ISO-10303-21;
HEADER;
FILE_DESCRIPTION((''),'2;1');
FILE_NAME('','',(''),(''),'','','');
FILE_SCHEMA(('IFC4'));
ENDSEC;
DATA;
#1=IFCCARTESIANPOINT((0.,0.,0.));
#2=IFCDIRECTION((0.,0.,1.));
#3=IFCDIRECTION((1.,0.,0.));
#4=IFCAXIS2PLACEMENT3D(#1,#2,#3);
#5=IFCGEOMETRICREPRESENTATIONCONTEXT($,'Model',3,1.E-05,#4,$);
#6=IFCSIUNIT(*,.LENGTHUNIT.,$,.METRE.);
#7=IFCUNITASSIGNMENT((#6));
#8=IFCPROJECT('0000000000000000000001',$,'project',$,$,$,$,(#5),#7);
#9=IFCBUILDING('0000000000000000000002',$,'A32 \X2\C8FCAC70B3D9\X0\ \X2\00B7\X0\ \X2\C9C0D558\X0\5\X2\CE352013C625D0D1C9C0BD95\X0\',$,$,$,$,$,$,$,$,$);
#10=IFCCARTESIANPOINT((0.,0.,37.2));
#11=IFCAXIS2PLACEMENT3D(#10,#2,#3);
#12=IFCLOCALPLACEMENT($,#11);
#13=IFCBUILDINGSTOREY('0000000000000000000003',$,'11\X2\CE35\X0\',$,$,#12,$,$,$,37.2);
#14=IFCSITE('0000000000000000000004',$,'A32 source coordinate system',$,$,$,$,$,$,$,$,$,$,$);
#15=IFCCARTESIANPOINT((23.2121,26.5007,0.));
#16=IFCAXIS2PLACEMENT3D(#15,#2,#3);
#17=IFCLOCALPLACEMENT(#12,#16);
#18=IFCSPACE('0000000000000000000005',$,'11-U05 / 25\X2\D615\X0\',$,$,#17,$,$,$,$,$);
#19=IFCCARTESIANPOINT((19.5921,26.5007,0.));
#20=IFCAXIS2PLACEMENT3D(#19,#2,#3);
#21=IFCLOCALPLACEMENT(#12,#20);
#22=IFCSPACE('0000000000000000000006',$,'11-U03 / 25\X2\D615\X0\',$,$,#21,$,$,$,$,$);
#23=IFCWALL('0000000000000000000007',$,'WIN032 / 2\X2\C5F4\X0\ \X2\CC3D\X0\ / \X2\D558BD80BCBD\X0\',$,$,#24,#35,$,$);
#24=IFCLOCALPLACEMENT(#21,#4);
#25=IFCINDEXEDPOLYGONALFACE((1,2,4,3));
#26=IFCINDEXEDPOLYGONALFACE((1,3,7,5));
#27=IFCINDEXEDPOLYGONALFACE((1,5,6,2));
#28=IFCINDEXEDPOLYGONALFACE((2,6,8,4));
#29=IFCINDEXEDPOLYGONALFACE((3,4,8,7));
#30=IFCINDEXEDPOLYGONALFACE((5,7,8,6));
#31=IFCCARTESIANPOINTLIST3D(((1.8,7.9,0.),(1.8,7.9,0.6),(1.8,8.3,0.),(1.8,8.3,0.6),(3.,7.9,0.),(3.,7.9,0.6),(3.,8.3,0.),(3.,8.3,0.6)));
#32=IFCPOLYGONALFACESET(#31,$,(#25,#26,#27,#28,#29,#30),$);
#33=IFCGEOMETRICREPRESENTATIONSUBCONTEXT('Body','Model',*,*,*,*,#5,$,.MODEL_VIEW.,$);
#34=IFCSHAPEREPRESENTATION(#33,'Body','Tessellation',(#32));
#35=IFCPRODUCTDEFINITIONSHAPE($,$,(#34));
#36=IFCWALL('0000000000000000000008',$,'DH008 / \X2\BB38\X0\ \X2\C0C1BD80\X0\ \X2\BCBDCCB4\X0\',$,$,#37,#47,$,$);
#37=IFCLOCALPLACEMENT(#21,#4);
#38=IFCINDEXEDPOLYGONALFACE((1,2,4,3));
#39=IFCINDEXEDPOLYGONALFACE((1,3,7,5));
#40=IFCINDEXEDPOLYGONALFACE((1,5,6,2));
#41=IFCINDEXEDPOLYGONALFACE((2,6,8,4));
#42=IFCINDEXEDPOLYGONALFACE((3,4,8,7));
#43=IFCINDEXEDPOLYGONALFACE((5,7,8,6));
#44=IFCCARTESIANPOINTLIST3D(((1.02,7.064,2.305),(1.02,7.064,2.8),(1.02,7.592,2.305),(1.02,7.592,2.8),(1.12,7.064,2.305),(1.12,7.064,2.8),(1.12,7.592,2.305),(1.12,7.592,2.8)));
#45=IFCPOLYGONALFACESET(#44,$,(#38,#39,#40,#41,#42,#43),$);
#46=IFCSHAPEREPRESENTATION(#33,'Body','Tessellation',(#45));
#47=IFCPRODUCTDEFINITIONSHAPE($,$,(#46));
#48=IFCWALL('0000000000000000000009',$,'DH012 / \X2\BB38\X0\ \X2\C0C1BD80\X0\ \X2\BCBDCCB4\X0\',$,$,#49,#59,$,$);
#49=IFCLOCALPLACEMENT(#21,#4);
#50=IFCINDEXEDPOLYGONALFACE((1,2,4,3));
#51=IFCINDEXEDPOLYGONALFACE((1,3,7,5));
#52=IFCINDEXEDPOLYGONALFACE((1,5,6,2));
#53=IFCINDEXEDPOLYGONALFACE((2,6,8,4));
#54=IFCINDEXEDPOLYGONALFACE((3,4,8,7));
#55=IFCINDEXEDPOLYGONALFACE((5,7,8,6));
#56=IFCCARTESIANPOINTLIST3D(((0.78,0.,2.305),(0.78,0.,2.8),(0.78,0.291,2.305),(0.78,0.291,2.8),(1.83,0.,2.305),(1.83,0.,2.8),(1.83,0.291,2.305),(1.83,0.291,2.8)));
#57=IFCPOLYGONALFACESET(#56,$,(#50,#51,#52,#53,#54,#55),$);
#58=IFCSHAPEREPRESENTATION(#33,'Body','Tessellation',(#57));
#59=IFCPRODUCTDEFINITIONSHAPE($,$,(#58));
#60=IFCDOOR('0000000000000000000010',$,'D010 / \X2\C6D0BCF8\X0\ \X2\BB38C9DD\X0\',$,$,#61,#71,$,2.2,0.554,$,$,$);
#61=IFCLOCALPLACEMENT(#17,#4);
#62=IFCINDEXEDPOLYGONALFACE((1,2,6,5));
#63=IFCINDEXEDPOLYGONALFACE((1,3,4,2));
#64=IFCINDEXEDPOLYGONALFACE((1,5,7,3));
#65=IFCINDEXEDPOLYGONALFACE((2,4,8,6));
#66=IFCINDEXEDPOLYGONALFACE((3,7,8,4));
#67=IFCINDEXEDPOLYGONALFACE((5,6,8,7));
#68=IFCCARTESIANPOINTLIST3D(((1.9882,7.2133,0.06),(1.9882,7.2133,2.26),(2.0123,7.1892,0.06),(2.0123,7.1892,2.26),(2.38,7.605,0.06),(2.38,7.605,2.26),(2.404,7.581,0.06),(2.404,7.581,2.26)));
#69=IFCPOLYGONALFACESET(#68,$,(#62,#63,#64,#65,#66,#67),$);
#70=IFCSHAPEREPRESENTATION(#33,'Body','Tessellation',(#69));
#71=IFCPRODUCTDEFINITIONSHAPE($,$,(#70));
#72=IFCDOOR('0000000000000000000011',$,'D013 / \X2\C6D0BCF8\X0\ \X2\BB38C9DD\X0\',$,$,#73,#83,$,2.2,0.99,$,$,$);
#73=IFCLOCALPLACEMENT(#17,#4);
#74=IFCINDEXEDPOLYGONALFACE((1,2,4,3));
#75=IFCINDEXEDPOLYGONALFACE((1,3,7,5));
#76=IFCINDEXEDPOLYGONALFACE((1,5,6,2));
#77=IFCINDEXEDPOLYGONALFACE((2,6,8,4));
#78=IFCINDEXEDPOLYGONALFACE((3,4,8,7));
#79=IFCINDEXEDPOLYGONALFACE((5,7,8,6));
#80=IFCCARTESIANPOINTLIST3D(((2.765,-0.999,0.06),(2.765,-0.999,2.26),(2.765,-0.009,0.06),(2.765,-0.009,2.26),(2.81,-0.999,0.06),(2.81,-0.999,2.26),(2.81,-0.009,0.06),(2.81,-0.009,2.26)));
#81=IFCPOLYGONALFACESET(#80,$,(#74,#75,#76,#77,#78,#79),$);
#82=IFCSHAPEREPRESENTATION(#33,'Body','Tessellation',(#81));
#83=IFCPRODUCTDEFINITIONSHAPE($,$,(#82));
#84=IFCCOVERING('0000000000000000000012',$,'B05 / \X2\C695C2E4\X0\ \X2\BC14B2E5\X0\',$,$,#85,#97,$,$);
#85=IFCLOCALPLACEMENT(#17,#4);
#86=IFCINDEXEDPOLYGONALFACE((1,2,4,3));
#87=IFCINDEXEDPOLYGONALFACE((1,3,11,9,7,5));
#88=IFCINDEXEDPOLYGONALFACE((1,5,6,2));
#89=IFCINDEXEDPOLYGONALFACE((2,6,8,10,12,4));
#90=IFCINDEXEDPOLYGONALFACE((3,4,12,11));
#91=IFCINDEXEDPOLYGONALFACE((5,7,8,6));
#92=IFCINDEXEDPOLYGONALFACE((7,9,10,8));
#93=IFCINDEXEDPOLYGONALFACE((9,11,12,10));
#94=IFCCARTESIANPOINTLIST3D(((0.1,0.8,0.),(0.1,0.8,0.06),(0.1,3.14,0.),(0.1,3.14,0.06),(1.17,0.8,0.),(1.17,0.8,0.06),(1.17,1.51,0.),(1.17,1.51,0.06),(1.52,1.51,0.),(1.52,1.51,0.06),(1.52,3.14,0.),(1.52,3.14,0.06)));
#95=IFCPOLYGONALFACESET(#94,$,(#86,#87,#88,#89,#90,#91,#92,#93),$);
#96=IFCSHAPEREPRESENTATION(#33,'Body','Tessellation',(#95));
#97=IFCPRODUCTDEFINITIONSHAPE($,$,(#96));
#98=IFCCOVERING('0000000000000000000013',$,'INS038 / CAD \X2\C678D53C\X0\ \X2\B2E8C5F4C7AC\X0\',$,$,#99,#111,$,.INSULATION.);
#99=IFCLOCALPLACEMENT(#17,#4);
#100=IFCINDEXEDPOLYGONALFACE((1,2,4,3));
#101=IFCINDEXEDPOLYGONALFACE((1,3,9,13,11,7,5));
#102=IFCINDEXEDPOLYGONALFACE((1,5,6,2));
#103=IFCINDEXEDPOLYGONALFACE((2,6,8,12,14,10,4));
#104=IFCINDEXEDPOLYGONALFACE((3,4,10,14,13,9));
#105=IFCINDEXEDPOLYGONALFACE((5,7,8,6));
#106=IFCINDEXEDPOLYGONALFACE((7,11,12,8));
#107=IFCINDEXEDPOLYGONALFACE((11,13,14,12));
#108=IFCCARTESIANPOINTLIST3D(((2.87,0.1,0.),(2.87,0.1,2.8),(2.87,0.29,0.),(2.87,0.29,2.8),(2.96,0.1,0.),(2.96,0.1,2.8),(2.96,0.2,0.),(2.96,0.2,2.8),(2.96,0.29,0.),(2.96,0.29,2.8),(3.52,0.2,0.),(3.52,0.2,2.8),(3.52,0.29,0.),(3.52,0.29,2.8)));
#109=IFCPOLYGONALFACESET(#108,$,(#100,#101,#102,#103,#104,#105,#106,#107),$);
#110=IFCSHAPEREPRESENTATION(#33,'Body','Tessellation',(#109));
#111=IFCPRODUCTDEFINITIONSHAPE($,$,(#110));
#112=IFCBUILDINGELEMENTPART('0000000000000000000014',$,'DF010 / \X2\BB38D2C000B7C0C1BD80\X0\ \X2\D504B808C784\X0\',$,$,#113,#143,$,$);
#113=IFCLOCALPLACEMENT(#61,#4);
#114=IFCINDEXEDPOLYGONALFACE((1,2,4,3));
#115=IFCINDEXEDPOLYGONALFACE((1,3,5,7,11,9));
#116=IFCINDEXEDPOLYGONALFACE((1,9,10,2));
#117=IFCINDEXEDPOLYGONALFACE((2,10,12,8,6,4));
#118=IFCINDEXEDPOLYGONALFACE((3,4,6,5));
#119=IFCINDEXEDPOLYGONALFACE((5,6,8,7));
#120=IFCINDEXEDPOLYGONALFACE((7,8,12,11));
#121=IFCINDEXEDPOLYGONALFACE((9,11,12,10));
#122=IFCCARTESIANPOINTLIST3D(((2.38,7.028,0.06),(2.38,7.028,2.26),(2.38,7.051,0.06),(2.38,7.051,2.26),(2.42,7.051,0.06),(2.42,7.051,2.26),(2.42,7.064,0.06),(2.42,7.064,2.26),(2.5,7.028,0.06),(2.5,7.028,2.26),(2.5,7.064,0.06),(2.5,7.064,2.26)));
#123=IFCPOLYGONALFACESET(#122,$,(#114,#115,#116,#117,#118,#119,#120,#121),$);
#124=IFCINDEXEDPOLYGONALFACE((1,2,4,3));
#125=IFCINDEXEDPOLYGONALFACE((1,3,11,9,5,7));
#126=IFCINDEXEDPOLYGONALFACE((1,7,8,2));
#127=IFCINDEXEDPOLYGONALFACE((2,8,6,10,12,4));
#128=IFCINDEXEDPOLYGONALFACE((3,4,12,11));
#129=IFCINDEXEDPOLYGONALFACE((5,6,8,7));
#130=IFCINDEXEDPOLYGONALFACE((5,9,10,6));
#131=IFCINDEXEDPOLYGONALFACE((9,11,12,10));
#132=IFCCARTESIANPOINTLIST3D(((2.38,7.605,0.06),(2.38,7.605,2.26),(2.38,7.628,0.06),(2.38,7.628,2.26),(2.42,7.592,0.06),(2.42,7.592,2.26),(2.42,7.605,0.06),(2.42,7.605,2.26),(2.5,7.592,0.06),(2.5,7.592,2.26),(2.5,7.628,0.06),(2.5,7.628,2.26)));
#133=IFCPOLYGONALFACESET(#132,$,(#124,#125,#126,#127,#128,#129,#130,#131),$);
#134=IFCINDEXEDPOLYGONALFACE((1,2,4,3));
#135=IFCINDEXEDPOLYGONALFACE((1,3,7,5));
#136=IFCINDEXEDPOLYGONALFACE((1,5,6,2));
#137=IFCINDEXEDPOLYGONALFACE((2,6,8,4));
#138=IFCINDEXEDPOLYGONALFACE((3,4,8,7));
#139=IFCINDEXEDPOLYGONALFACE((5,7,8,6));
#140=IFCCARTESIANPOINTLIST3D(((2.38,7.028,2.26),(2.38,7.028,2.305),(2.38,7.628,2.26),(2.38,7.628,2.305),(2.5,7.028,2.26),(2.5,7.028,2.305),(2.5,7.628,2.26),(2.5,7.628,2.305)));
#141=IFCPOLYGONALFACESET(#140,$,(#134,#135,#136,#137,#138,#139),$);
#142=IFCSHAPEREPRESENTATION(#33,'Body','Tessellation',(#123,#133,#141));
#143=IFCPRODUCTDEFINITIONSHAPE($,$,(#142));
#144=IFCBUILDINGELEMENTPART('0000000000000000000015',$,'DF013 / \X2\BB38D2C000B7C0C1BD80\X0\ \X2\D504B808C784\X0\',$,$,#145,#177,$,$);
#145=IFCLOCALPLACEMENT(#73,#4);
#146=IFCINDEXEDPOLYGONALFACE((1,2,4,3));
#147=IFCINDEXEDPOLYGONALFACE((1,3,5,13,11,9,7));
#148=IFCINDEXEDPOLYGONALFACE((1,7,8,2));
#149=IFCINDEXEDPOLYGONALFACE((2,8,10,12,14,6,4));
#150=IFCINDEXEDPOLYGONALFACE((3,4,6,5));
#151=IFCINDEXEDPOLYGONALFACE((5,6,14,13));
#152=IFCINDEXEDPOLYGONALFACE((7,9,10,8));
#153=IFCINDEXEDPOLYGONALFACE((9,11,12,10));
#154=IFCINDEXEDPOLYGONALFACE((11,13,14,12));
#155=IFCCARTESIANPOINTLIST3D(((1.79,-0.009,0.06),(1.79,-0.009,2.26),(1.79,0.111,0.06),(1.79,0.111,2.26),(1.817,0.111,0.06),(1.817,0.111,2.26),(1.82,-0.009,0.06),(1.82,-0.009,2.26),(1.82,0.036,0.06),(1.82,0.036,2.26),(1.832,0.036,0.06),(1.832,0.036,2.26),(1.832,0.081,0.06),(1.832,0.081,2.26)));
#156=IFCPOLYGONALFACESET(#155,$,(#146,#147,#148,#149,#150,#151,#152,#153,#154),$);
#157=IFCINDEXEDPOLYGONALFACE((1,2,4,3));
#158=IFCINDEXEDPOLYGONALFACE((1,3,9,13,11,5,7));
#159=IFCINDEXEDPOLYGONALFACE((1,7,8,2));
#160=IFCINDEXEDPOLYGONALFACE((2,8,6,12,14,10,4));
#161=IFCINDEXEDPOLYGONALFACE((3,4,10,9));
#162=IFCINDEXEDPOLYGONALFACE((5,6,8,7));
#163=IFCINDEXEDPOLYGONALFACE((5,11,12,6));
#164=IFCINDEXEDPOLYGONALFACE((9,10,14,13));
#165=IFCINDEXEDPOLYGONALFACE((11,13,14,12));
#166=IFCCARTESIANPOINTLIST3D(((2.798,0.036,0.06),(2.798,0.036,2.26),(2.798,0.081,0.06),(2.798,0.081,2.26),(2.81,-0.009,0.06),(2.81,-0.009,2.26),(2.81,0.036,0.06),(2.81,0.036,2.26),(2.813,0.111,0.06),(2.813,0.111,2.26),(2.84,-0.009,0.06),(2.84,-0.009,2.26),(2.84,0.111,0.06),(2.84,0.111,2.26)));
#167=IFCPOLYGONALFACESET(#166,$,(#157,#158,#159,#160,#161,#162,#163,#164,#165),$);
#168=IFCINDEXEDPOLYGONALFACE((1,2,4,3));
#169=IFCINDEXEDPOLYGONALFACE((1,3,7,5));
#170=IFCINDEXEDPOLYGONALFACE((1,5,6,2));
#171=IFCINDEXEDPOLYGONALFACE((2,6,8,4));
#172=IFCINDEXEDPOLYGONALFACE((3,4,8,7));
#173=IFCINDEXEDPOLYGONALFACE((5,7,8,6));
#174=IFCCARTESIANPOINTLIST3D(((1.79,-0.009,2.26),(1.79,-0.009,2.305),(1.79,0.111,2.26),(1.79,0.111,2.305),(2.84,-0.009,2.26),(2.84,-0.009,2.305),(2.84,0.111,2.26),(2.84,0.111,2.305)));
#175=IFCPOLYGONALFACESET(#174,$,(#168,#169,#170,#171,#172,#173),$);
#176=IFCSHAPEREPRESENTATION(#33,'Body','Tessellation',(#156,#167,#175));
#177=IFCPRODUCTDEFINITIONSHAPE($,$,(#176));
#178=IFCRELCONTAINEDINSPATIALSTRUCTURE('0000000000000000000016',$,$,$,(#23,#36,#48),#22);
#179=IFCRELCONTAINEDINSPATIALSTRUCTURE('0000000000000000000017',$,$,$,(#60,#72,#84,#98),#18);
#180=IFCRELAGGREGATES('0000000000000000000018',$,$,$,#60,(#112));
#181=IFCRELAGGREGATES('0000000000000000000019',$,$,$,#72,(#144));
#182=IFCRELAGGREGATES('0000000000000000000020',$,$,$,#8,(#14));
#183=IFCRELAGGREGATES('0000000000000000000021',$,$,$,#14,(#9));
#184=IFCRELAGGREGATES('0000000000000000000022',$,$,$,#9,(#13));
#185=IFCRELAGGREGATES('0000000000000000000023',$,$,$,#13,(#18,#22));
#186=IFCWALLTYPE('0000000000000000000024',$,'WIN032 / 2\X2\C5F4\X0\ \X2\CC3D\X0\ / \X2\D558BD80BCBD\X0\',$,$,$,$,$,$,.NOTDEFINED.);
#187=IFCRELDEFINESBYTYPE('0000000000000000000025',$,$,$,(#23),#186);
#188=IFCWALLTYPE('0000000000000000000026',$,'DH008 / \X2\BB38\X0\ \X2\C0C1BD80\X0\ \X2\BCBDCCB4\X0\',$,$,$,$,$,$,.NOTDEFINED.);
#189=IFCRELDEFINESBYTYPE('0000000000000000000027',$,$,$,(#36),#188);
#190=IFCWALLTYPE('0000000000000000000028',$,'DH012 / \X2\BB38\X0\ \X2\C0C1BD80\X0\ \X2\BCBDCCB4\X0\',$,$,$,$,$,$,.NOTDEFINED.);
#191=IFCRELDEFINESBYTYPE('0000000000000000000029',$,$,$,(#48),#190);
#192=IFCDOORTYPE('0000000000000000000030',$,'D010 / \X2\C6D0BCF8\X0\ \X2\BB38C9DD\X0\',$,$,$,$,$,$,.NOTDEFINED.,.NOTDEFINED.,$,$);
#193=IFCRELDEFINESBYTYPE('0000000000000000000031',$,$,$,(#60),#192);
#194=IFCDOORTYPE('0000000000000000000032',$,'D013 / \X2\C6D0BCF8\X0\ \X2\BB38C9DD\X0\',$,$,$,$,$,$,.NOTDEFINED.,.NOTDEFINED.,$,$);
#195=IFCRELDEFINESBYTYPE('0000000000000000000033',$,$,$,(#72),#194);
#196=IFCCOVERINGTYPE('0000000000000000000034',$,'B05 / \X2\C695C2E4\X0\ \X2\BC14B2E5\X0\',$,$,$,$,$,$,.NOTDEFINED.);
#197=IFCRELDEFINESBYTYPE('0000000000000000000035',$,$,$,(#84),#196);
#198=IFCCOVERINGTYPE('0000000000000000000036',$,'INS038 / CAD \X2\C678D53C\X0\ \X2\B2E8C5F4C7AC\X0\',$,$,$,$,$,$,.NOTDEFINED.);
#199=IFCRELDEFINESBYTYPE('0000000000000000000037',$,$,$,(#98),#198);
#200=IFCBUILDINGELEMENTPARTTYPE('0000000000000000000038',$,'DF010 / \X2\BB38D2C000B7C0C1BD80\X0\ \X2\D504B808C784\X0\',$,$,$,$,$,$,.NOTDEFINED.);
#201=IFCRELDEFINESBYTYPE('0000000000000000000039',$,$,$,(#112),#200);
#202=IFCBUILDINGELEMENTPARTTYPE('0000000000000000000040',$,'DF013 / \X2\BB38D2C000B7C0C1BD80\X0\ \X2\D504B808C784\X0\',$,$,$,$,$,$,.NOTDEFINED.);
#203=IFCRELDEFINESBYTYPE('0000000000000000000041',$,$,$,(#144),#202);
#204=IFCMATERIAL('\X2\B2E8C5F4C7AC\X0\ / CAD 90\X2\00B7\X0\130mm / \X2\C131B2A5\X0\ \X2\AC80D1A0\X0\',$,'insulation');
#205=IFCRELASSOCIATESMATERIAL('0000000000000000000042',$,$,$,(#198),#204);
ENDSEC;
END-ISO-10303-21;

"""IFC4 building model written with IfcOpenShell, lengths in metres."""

from ifc_helpers import new_model, si_unit, frame, origin, origin_with_axes, place, context, subcontext, project, spatial, polyline, outline, extrude, source, transform, mapped, material, type_object, type_shapes, element, aggregate, save


model = new_model("IFC4")

# Units and contexts
model_context = context("Model", 3, precision=1e-05, world=origin_with_axes())
body_context = subcontext(model_context, "Body", "Model", "MODEL_VIEW")
ifc_project = project(units=[si_unit("LENGTHUNIT", "METRE")], contexts=[model_context])

# Site, building, storey, space
storey_placement = place(None, frame((0.0, 0.0, 37.2), z_axis=(0.0, 0.0, 1.0), x_axis=(1.0, 0.0, 0.0)))
space_1_placement = place(storey_placement, frame((23.2121, 26.5007, 0.0), z_axis=(0.0, 0.0, 1.0), x_axis=(1.0, 0.0, 0.0)))
site = spatial("IfcSite", under=ifc_project, Name="A32 source coordinate system")
building = spatial("IfcBuilding", under=site, Name="A32 주거동 · 지하5층–옥탑지붕")
storey = spatial("IfcBuildingStorey", under=building, at=storey_placement, Name="11층", Elevation=37.2)
space_1 = spatial("IfcSpace", under=storey, at=space_1_placement, Name="11-U05 / 25형")

# Shared definitions
space_2_placement = place(storey_placement, frame((19.5921, 26.5007, 0.0), z_axis=(0.0, 0.0, 1.0), x_axis=(1.0, 0.0, 0.0)))
space_2 = spatial("IfcSpace", under=storey, at=space_2_placement, Name="11-U03 / 25형")

# Walls
wall_type_1 = type_object("IfcWallType", Name="WIN032 / 2열 창 / 하부벽", PredefinedType="NOTDEFINED")
shared_shape_1 = source(origin(), body_context, "Body", "SweptSolid", [
    extrude(outline(polyline([(3.0, 7.9), (1.8, 7.9), (1.8, 8.3), (3.0, 8.3), (3.0, 7.9)])), origin(), (0.0, 0.0, 1.0), 0.6),
])
type_shapes(wall_type_1, [shared_shape_1])
wall_1_placement = place(space_2_placement, origin_with_axes())
element("IfcWall", 1, at=wall_1_placement, inside=space_2, type_object=wall_type_1, Name="WIN032 / 2열 창 / 하부벽", context=body_context, shape_type="MappedRepresentation", body=[
    mapped(shared_shape_1, transform((0.0, 0.0, 0.0), scale=1.0)),
])
wall_type_2 = type_object("IfcWallType", Name="DH008 / 문 상부 벽체", PredefinedType="NOTDEFINED")
shared_shape_2 = source(origin(), body_context, "Body", "SweptSolid", [
    extrude(outline(polyline([(1.12, 7.064), (1.02, 7.064), (1.02, 7.592), (1.12, 7.592), (1.12, 7.064)])), frame((0.0, 0.0, 2.305)), (0.0, 0.0, 1.0), 0.495),
])
type_shapes(wall_type_2, [shared_shape_2])
wall_2_placement = place(space_2_placement, origin_with_axes())
element("IfcWall", 2, at=wall_2_placement, inside=space_2, type_object=wall_type_2, Name="DH008 / 문 상부 벽체", context=body_context, shape_type="MappedRepresentation", body=[
    mapped(shared_shape_2, transform((0.0, 0.0, 0.0), scale=1.0)),
])
wall_type_3 = type_object("IfcWallType", Name="DH012 / 문 상부 벽체", PredefinedType="NOTDEFINED")
shared_shape_3 = source(origin(), body_context, "Body", "SweptSolid", [
    extrude(outline(polyline([(0.78, 0.0), (0.78, 0.291), (1.83, 0.291), (1.83, 0.0), (0.78, 0.0)])), frame((0.0, 0.0, 2.305)), (0.0, 0.0, 1.0), 0.495),
])
type_shapes(wall_type_3, [shared_shape_3])
wall_3_placement = place(space_2_placement, origin_with_axes())
element("IfcWall", 3, at=wall_3_placement, inside=space_2, type_object=wall_type_3, Name="DH012 / 문 상부 벽체", context=body_context, shape_type="MappedRepresentation", body=[
    mapped(shared_shape_3, transform((0.0, 0.0, 0.0), scale=1.0)),
])

# Doors
door_type_1 = type_object("IfcDoorType", Name="D010 / 원본 문짝", OperationType="NOTDEFINED", PredefinedType="NOTDEFINED")
shared_shape_4 = source(origin(), body_context, "Body", "SweptSolid", [
    extrude(outline(polyline([(2.0123, 7.1892), (1.9882, 7.2133), (2.38, 7.605), (2.404, 7.581), (2.0123, 7.1892)])), frame((0.0, 0.0, 0.06)), (0.0, 0.0, 1.0), 2.2),
])
type_shapes(door_type_1, [shared_shape_4])
door_1_placement = place(space_1_placement, origin_with_axes())
door_1 = element("IfcDoor", 4, at=door_1_placement, inside=space_1, type_object=door_type_1, Name="D010 / 원본 문짝", OverallHeight=2.2, OverallWidth=0.554, context=body_context, shape_type="MappedRepresentation", body=[
    mapped(shared_shape_4, transform((0.0, 0.0, 0.0), scale=1.0)),
])
door_type_2 = type_object("IfcDoorType", Name="D013 / 원본 문짝", OperationType="NOTDEFINED", PredefinedType="NOTDEFINED")
shared_shape_5 = source(origin(), body_context, "Body", "SweptSolid", [
    extrude(outline(polyline([(2.81, -0.009), (2.81, -0.999), (2.765, -0.999), (2.765, -0.009), (2.81, -0.009)])), frame((0.0, 0.0, 0.06)), (0.0, 0.0, 1.0), 2.2),
])
type_shapes(door_type_2, [shared_shape_5])
door_2_placement = place(space_1_placement, origin_with_axes())
door_2 = element("IfcDoor", 5, at=door_2_placement, inside=space_1, type_object=door_type_2, Name="D013 / 원본 문짝", OverallHeight=2.2, OverallWidth=0.99, context=body_context, shape_type="MappedRepresentation", body=[
    mapped(shared_shape_5, transform((0.0, 0.0, 0.0), scale=1.0)),
])

# Coverings
covering_type_1 = type_object("IfcCoveringType", Name="B05 / 욕실 바닥", PredefinedType="NOTDEFINED")
shared_shape_6 = source(origin(), body_context, "Body", "SweptSolid", [
    extrude(outline(polyline([(0.1, 3.14), (1.52, 3.14), (1.52, 1.51), (1.17, 1.51), (1.17, 0.8), (0.1, 0.8), (0.1, 3.14)])), origin(), (0.0, 0.0, 1.0), 0.06),
])
type_shapes(covering_type_1, [shared_shape_6])
covering_1_placement = place(space_1_placement, origin_with_axes())
element("IfcCovering", 6, at=covering_1_placement, inside=space_1, type_object=covering_type_1, Name="B05 / 욕실 바닥", context=body_context, shape_type="MappedRepresentation", body=[
    mapped(shared_shape_6, transform((0.0, 0.0, 0.0), scale=1.0)),
])
ifc_material = material(Name="단열재 / CAD 90·130mm / 성능 검토", Category="insulation")
covering_type_2 = type_object("IfcCoveringType", Name="INS038 / CAD 외피 단열재", PredefinedType="NOTDEFINED", material=ifc_material)
shared_shape_7 = source(origin(), body_context, "Body", "SweptSolid", [
    extrude(outline(polyline([(2.96, 0.2), (2.96, 0.1), (2.87, 0.1), (2.87, 0.29), (2.96, 0.29), (3.52, 0.29), (3.52, 0.2), (2.96, 0.2)])), origin(), (0.0, 0.0, 1.0), 2.8),
])
type_shapes(covering_type_2, [shared_shape_7])
covering_2_placement = place(space_1_placement, origin_with_axes())
element("IfcCovering", 7, at=covering_2_placement, inside=space_1, type_object=covering_type_2, Name="INS038 / CAD 외피 단열재", PredefinedType="INSULATION", context=body_context, shape_type="MappedRepresentation", body=[
    mapped(shared_shape_7, transform((0.0, 0.0, 0.0), scale=1.0)),
])

# Building element parts
building_element_part_type_1 = type_object("IfcBuildingElementPartType", Name="DF010 / 문틀·상부 프레임", PredefinedType="NOTDEFINED")
shared_shape_8 = source(origin(), body_context, "Body", "SweptSolid", [
    extrude(outline(polyline([(2.38, 7.028), (2.38, 7.051), (2.42, 7.051), (2.42, 7.064), (2.5, 7.064), (2.5, 7.028), (2.38, 7.028)])), frame((0.0, 0.0, 0.06)), (0.0, 0.0, 1.0), 2.2),
    extrude(outline(polyline([(2.5, 7.592), (2.42, 7.592), (2.42, 7.605), (2.38, 7.605), (2.38, 7.628), (2.5, 7.628), (2.5, 7.592)])), frame((0.0, 0.0, 0.06)), (0.0, 0.0, 1.0), 2.2),
    extrude(outline(polyline([(2.38, 7.028), (2.38, 7.628), (2.5, 7.628), (2.5, 7.028), (2.38, 7.028)])), frame((0.0, 0.0, 2.26)), (0.0, 0.0, 1.0), 0.045),
])
type_shapes(building_element_part_type_1, [shared_shape_8])
building_element_part_1_placement = place(door_1_placement, origin_with_axes())
building_element_part_1 = element("IfcBuildingElementPart", 8, at=building_element_part_1_placement, type_object=building_element_part_type_1, Name="DF010 / 문틀·상부 프레임", context=body_context, shape_type="MappedRepresentation", body=[
    mapped(shared_shape_8, transform((0.0, 0.0, 0.0), scale=1.0)),
])
aggregate(door_1, [building_element_part_1])
building_element_part_type_2 = type_object("IfcBuildingElementPartType", Name="DF013 / 문틀·상부 프레임", PredefinedType="NOTDEFINED")
shared_shape_9 = source(origin(), body_context, "Body", "SweptSolid", [
    extrude(outline(polyline([(1.79, 0.111), (1.817, 0.111), (1.832, 0.081), (1.832, 0.036), (1.82, 0.036), (1.82, -0.009), (1.79, -0.009), (1.79, 0.111)])), frame((0.0, 0.0, 0.06)), (0.0, 0.0, 1.0), 2.2),
    extrude(outline(polyline([(2.81, -0.009), (2.81, 0.036), (2.798, 0.036), (2.798, 0.081), (2.813, 0.111), (2.84, 0.111), (2.84, -0.009), (2.81, -0.009)])), frame((0.0, 0.0, 0.06)), (0.0, 0.0, 1.0), 2.2),
    extrude(outline(polyline([(1.79, -0.009), (1.79, 0.111), (2.84, 0.111), (2.84, -0.009), (1.79, -0.009)])), frame((0.0, 0.0, 2.26)), (0.0, 0.0, 1.0), 0.045),
])
type_shapes(building_element_part_type_2, [shared_shape_9])
building_element_part_2_placement = place(door_2_placement, origin_with_axes())
building_element_part_2 = element("IfcBuildingElementPart", 9, at=building_element_part_2_placement, type_object=building_element_part_type_2, Name="DF013 / 문틀·상부 프레임", context=body_context, shape_type="MappedRepresentation", body=[
    mapped(shared_shape_9, transform((0.0, 0.0, 0.0), scale=1.0)),
])
aggregate(door_2, [building_element_part_2])

save(model, "model.ifc")
